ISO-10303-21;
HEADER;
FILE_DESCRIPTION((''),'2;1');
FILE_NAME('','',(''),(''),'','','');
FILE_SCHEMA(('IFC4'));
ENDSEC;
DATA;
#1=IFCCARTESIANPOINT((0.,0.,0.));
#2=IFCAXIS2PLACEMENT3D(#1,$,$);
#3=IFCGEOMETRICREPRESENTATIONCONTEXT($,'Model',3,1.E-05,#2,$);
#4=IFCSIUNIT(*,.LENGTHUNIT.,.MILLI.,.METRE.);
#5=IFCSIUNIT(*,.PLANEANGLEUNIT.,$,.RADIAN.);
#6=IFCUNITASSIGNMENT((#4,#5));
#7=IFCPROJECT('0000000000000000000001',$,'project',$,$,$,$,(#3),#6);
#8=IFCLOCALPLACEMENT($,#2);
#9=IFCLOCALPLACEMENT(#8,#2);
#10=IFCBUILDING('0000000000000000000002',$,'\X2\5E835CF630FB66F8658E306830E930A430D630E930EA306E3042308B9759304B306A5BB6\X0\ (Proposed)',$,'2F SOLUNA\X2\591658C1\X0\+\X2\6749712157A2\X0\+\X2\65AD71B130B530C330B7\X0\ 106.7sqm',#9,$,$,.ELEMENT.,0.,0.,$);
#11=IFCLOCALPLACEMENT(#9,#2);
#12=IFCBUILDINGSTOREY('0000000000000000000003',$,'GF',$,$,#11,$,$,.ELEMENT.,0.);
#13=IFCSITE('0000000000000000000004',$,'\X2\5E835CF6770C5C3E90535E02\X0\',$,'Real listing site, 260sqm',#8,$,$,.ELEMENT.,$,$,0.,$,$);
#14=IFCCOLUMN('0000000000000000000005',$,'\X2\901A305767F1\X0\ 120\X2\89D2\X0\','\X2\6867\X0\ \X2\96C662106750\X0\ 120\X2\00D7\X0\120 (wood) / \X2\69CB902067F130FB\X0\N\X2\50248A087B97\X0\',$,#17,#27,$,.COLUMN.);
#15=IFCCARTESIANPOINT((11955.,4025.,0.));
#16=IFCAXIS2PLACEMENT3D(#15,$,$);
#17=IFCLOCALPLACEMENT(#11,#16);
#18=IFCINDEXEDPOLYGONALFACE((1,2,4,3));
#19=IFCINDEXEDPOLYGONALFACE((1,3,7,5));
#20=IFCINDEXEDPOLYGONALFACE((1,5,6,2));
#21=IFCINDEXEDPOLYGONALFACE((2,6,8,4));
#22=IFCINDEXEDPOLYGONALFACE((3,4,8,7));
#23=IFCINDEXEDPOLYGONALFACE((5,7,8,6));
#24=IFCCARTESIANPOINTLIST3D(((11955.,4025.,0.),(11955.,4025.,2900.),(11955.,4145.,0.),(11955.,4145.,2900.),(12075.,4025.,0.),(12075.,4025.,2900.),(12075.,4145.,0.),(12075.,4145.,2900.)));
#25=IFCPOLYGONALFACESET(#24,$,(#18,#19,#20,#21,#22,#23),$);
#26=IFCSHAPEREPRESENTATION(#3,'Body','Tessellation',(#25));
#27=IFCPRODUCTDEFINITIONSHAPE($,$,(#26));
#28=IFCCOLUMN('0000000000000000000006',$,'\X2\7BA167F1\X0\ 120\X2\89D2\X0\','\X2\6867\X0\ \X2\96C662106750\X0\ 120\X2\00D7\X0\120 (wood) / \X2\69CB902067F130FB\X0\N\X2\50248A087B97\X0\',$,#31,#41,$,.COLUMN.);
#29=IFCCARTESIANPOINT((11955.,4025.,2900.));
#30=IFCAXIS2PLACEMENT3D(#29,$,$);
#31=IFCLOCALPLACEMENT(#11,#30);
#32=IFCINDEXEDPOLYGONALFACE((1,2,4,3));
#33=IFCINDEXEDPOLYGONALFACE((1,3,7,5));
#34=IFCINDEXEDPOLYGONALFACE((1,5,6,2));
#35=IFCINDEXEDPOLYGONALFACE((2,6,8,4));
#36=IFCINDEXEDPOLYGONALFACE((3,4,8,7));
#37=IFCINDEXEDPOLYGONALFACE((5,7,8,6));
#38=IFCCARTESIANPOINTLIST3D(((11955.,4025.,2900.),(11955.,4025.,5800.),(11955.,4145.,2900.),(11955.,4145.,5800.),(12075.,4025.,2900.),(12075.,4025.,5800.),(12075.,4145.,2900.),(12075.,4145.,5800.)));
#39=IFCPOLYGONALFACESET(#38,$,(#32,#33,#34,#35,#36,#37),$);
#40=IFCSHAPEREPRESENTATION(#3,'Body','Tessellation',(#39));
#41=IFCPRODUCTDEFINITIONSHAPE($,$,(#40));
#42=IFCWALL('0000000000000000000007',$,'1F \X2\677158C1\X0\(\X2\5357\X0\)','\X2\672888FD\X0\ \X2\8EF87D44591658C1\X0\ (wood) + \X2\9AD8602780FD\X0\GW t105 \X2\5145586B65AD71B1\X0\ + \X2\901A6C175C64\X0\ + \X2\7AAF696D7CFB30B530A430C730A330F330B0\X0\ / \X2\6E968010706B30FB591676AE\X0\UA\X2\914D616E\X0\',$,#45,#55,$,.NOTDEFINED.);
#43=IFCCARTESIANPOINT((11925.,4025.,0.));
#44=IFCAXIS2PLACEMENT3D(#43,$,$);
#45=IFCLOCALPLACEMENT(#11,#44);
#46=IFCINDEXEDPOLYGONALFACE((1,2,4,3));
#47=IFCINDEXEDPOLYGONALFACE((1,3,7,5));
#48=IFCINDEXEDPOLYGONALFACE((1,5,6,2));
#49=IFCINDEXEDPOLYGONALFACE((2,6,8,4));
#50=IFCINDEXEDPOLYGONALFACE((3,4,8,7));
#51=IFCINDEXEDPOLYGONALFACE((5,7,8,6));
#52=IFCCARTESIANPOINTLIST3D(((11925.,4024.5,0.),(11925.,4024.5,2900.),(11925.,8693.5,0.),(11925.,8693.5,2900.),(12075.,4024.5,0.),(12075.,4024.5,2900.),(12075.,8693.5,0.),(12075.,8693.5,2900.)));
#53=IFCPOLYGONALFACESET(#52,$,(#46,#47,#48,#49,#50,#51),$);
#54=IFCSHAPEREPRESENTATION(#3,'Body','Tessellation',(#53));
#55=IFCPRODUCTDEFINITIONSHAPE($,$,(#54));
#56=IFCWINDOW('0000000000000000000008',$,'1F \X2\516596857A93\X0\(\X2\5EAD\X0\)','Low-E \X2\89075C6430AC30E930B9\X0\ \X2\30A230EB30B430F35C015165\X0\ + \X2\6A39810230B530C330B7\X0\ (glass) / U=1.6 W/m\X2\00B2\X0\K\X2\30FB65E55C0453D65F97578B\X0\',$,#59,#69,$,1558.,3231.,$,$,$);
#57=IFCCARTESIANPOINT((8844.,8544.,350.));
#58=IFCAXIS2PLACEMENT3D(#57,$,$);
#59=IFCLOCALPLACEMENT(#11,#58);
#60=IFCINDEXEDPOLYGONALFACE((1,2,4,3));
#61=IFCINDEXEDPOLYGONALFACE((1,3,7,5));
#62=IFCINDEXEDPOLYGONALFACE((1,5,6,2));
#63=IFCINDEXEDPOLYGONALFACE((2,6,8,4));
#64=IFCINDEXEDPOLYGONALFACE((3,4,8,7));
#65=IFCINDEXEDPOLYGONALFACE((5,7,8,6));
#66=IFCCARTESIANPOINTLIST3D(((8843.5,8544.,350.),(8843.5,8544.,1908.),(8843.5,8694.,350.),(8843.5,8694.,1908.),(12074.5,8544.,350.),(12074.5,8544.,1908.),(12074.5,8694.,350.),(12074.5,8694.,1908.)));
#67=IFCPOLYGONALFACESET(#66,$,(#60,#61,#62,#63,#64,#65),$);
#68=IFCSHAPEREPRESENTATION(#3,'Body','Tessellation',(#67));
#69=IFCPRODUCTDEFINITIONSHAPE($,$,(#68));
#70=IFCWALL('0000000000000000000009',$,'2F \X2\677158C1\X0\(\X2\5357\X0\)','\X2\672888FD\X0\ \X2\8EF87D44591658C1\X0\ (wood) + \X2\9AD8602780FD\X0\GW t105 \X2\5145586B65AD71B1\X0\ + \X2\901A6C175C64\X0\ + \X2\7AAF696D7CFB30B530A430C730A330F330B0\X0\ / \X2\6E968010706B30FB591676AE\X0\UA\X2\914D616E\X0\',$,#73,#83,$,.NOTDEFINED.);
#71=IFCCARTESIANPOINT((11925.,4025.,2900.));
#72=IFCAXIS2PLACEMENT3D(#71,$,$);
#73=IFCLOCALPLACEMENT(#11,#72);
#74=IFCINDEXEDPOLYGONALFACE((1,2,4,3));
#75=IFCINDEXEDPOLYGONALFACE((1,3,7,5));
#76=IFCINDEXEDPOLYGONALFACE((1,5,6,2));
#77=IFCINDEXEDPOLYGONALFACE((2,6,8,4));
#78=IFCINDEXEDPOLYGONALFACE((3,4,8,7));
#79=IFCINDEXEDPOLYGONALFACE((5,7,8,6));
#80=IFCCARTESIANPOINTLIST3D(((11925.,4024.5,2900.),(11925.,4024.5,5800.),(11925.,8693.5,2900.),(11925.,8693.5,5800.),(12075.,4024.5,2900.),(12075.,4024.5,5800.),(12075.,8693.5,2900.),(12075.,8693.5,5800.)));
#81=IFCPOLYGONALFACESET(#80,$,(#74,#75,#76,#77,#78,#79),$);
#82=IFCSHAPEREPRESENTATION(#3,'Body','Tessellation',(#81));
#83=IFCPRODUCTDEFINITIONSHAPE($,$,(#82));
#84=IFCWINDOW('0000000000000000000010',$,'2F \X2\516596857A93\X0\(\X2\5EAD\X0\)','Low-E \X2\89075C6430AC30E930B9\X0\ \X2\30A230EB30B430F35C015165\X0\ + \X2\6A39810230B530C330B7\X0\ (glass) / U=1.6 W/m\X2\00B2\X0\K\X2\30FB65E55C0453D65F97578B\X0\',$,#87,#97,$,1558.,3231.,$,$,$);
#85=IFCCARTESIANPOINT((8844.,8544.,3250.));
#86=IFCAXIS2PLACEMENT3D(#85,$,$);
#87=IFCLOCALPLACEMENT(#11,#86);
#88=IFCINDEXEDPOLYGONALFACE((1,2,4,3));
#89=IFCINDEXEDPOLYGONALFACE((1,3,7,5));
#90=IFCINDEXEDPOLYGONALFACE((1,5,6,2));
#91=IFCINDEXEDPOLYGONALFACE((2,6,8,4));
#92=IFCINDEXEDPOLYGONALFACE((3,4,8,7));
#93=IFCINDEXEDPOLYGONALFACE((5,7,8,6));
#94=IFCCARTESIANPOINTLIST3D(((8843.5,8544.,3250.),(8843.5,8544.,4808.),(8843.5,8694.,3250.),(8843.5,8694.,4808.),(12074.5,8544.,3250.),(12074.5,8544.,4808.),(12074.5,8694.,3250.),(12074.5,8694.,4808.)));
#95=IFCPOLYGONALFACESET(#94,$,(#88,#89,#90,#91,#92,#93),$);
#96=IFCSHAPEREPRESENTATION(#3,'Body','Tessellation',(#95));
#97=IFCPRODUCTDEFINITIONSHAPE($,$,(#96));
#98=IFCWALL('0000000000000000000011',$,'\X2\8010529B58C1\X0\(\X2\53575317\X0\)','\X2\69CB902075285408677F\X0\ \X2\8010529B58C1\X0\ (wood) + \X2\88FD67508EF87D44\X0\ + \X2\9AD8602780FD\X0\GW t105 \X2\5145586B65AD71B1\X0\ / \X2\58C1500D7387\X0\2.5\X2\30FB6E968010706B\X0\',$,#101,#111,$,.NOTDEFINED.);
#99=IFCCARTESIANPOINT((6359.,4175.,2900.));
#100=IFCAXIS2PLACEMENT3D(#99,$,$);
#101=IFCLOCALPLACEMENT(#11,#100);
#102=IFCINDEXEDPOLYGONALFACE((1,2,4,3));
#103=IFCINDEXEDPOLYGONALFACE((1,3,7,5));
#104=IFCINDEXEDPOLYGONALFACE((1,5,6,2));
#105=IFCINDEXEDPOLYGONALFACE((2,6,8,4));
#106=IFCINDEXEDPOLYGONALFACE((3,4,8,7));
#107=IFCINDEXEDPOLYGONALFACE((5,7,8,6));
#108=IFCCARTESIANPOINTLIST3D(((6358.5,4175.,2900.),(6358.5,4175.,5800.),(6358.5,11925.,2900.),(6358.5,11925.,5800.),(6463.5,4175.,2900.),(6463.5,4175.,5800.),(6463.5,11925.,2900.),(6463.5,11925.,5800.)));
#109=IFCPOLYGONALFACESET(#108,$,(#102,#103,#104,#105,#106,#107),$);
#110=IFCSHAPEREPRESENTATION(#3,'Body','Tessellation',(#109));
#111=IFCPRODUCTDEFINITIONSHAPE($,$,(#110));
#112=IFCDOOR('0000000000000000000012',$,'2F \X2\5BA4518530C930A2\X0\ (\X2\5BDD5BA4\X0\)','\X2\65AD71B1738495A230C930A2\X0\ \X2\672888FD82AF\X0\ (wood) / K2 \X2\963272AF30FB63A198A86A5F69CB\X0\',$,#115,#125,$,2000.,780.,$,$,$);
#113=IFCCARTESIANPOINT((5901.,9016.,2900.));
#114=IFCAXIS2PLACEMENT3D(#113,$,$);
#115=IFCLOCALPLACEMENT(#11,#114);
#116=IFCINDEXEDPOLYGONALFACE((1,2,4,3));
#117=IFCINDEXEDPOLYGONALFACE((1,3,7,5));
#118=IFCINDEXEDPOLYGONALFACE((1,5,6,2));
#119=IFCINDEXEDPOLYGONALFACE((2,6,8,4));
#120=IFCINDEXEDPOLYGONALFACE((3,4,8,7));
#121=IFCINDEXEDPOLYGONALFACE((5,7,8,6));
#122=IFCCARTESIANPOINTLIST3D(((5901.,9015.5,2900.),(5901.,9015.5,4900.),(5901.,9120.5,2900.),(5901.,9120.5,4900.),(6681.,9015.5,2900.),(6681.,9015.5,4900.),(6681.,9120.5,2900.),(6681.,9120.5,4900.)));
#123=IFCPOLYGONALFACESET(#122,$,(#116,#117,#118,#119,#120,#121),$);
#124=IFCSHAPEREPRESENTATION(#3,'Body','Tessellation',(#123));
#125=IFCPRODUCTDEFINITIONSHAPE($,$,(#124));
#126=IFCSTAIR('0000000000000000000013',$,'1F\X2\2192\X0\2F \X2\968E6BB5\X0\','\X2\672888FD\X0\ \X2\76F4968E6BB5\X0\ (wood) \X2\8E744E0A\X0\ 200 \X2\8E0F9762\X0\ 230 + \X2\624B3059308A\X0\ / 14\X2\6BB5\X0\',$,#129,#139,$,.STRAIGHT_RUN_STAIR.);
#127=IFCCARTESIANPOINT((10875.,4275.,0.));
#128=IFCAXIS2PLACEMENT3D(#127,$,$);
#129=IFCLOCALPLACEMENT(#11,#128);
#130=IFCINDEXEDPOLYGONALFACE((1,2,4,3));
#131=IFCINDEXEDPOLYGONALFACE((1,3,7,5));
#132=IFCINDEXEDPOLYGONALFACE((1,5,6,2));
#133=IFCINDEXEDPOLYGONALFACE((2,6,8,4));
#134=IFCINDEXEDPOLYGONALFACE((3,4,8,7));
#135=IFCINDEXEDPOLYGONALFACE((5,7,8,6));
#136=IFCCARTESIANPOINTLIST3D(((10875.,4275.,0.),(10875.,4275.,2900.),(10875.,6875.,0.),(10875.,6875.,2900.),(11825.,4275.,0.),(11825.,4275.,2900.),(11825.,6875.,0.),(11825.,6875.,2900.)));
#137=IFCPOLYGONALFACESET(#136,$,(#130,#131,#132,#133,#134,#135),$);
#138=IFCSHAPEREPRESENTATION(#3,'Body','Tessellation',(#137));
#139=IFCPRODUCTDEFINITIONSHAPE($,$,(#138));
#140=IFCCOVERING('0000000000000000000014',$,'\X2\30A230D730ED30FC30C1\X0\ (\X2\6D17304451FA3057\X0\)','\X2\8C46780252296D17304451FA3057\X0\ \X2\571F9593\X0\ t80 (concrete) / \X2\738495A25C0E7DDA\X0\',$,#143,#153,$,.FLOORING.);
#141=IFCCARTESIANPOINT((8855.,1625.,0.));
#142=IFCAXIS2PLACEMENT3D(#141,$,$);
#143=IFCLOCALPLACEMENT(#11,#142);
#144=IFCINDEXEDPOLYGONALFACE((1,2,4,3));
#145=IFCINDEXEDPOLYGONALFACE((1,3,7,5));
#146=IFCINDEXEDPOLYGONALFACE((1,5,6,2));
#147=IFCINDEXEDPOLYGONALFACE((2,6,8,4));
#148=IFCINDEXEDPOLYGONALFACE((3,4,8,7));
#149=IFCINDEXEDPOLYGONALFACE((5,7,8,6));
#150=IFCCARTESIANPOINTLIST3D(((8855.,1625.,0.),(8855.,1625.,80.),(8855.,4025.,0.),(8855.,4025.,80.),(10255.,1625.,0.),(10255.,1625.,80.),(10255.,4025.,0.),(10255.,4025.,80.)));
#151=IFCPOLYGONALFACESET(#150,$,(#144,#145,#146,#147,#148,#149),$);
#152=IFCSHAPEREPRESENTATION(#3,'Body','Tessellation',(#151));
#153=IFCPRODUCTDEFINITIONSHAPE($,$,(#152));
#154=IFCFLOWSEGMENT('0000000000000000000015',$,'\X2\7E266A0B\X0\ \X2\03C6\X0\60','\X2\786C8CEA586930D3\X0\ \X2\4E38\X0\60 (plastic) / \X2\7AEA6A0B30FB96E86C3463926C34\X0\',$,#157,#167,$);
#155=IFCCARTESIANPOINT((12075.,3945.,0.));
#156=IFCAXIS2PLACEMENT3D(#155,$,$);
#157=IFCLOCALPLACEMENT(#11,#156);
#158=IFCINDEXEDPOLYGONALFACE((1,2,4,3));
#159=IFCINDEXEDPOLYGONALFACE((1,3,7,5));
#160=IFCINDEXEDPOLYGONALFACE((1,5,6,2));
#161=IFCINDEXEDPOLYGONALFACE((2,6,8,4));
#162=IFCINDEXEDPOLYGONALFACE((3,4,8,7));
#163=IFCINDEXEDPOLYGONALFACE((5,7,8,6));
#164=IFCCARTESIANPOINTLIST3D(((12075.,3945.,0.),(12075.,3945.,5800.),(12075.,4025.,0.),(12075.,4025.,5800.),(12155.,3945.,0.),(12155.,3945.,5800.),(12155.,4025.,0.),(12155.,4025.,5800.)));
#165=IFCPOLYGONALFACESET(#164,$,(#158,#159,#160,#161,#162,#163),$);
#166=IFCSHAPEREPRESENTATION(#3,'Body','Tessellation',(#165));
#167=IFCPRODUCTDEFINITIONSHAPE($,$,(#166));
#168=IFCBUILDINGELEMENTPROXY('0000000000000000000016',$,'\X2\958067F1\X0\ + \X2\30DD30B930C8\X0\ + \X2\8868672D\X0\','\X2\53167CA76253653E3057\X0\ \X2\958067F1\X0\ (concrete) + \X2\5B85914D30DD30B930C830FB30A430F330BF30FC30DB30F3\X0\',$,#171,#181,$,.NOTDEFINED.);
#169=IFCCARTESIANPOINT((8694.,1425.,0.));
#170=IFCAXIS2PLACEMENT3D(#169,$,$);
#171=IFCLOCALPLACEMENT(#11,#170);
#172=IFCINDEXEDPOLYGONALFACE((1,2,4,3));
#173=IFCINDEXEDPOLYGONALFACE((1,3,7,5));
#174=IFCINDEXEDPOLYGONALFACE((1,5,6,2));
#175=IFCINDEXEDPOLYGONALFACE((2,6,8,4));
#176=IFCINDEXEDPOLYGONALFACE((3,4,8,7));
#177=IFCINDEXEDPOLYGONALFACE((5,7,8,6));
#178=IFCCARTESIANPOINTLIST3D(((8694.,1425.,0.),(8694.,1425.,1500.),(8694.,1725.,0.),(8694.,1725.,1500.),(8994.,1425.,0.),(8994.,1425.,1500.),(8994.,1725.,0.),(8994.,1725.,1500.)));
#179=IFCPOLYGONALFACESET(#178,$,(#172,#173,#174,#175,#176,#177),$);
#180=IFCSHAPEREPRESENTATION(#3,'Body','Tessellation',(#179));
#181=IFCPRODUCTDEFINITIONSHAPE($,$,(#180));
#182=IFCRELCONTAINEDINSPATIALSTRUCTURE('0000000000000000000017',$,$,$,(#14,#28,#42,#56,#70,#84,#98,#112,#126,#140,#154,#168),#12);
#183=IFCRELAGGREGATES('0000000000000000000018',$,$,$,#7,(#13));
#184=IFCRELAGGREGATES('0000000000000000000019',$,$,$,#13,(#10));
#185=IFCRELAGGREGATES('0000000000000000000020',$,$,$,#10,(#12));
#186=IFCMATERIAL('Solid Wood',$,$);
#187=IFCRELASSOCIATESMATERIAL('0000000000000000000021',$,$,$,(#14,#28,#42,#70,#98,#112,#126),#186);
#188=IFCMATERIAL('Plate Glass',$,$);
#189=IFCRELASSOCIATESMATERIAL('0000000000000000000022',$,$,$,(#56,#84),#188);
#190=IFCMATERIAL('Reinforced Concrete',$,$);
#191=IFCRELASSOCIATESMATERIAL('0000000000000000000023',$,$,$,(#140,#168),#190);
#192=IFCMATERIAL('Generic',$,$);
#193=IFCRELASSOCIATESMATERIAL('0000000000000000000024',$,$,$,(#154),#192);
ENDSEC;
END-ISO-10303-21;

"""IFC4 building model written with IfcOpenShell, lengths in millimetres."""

from ifc_helpers import new_model, si_unit, frame, frame_2d, origin, place, context, project, spatial, rectangle, extrude, material, element, fill, save


model = new_model("IFC4")

# Units and contexts
model_context = context("Model", 3, precision=1e-05, world=origin())
ifc_project = project(units=[si_unit("LENGTHUNIT", "METRE", prefix="MILLI"), si_unit("PLANEANGLEUNIT", "RADIAN")], contexts=[model_context])

# Site, building, storey
site_placement = place(None, origin())
site = spatial("IfcSite", under=ifc_project, at=site_placement, Name="広島県尾道市", ObjectType="Real listing site, 260sqm", CompositionType="ELEMENT", RefElevation=0.0)
building_placement = place(site_placement, origin())
building = spatial("IfcBuilding", under=site, at=building_placement, Name="広島・書斎とライブラリのある静かな家 (Proposed)", ObjectType="2F SOLUNA外壁+杉無垢+断熱サッシ 106.7sqm", CompositionType="ELEMENT", ElevationOfRefHeight=0.0, ElevationOfTerrain=0.0)
storey_placement = place(building_placement, origin())
storey = spatial("IfcBuildingStorey", under=building, at=storey_placement, Name="GF", CompositionType="ELEMENT", Elevation=0.0)

# Columns
ifc_material_1 = material(Name="Solid Wood")
column_1_placement = place(storey_placement, frame((11955.0, 4025.0, 0.0)))
element("IfcColumn", 1, at=column_1_placement, inside=storey, material=ifc_material_1, Name="通し柱 120角", Description="桧 集成材 120×120 (wood) / 構造柱・N値計算", PredefinedType="COLUMN", context=model_context, shape_type="SweptSolid", body=[
    extrude(rectangle(XDim=120.0, YDim=120.0, at=frame_2d((60.0, 60.0))), frame((11955.0, 4025.0, 0.0)), (0.0, 0.0, 1.0), 2900.0),
])
column_2_placement = place(storey_placement, frame((11955.0, 4025.0, 2900.0)))
element("IfcColumn", 2, at=column_2_placement, inside=storey, material=ifc_material_1, Name="管柱 120角", Description="桧 集成材 120×120 (wood) / 構造柱・N値計算", PredefinedType="COLUMN", context=model_context, shape_type="SweptSolid", body=[
    extrude(rectangle(XDim=120.0, YDim=120.0, at=frame_2d((60.0, 60.0))), frame((11955.0, 4025.0, 2900.0)), (0.0, 0.0, 1.0), 2900.0),
])

# Wall, opening, window
wall_1_placement = place(storey_placement, frame((11925.0, 4025.0, 0.0)))
wall_1 = element("IfcWall", 3, at=wall_1_placement, inside=storey, material=ifc_material_1, Name="1F 東壁(南)", Description="木製 軸組外壁 (wood) + 高性能GW t105 充填断熱 + 通気層 + 窯業系サイディング / 準耐火・外皮UA配慮", PredefinedType="NOTDEFINED", context=model_context, shape_type="SweptSolid", body=[
    extrude(rectangle(XDim=150.0, YDim=4669.0, at=frame_2d((75.0, 2334.0))), frame((11925.0, 4025.0, 0.0)), (0.0, 0.0, 1.0), 2900.0),
])
opening_1_placement = place(storey_placement, frame((8844.0, 8544.0, 350.0)))
opening_1 = element("IfcOpeningElement", 4, at=opening_1_placement, cuts=wall_1, PredefinedType="NOTDEFINED", context=model_context, shape_type="SweptSolid", body=[
    extrude(rectangle(XDim=3231.0, YDim=150.0, at=frame_2d((1615.0, 75.0))), frame((8844.0, 8544.0, 350.0)), (0.0, 0.0, 1.0), 1558.0),
])
ifc_material_2 = material(Name="Plate Glass")
window_1_placement = place(storey_placement, frame((8844.0, 8544.0, 350.0)))
window_1 = element("IfcWindow", 5, at=window_1_placement, inside=storey, material=ifc_material_2, Name="1F 入隅窓(庭)", Description="Low-E 複層ガラス アルゴン封入 + 樹脂サッシ (glass) / U=1.6 W/m²K・日射取得型", OverallHeight=1558.0, OverallWidth=3231.0, context=model_context, shape_type="SweptSolid", body=[
    extrude(rectangle(XDim=3231.0, YDim=150.0, at=frame_2d((1615.0, 75.0))), frame((8844.0, 8544.0, 350.0)), (0.0, 0.0, 1.0), 1558.0),
])
fill(opening_1, window_1)

# Wall, opening, window
wall_2_placement = place(storey_placement, frame((11925.0, 4025.0, 2900.0)))
wall_2 = element("IfcWall", 6, at=wall_2_placement, inside=storey, material=ifc_material_1, Name="2F 東壁(南)", Description="木製 軸組外壁 (wood) + 高性能GW t105 充填断熱 + 通気層 + 窯業系サイディング / 準耐火・外皮UA配慮", PredefinedType="NOTDEFINED", context=model_context, shape_type="SweptSolid", body=[
    extrude(rectangle(XDim=150.0, YDim=4669.0, at=frame_2d((75.0, 2334.0))), frame((11925.0, 4025.0, 2900.0)), (0.0, 0.0, 1.0), 2900.0),
])
opening_2_placement = place(storey_placement, frame((8844.0, 8544.0, 3250.0)))
opening_2 = element("IfcOpeningElement", 7, at=opening_2_placement, cuts=wall_2, PredefinedType="NOTDEFINED", context=model_context, shape_type="SweptSolid", body=[
    extrude(rectangle(XDim=3231.0, YDim=150.0, at=frame_2d((1615.0, 75.0))), frame((8844.0, 8544.0, 3250.0)), (0.0, 0.0, 1.0), 1558.0),
])
window_2_placement = place(storey_placement, frame((8844.0, 8544.0, 3250.0)))
window_2 = element("IfcWindow", 8, at=window_2_placement, inside=storey, material=ifc_material_2, Name="2F 入隅窓(庭)", Description="Low-E 複層ガラス アルゴン封入 + 樹脂サッシ (glass) / U=1.6 W/m²K・日射取得型", OverallHeight=1558.0, OverallWidth=3231.0, context=model_context, shape_type="SweptSolid", body=[
    extrude(rectangle(XDim=3231.0, YDim=150.0, at=frame_2d((1615.0, 75.0))), frame((8844.0, 8544.0, 3250.0)), (0.0, 0.0, 1.0), 1558.0),
])
fill(opening_2, window_2)

# Wall, opening, door
wall_3_placement = place(storey_placement, frame((6359.0, 4175.0, 2900.0)))
wall_3 = element("IfcWall", 9, at=wall_3_placement, inside=storey, material=ifc_material_1, Name="耐力壁(南北)", Description="構造用合板 耐力壁 (wood) + 製材軸組 + 高性能GW t105 充填断熱 / 壁倍率2.5・準耐火", PredefinedType="NOTDEFINED", context=model_context, shape_type="SweptSolid", body=[
    extrude(rectangle(XDim=105.0, YDim=7750.0, at=frame_2d((52.0, 3875.0))), frame((6359.0, 4175.0, 2900.0)), (0.0, 0.0, 1.0), 2900.0),
])
opening_3_placement = place(storey_placement, frame((5901.0, 9016.0, 2900.0)))
opening_3 = element("IfcOpeningElement", 10, at=opening_3_placement, cuts=wall_3, PredefinedType="NOTDEFINED", context=model_context, shape_type="SweptSolid", body=[
    extrude(rectangle(XDim=780.0, YDim=105.0, at=frame_2d((390.0, 52.0))), frame((5901.0, 9016.0, 2900.0)), (0.0, 0.0, 1.0), 2000.0),
])
door_1_placement = place(storey_placement, frame((5901.0, 9016.0, 2900.0)))
door_1 = element("IfcDoor", 11, at=door_1_placement, inside=storey, material=ifc_material_1, Name="2F 室内ドア (寝室)", Description="断熱玄関ドア 木製芯 (wood) / K2 防犯・採風機構", OverallHeight=2000.0, OverallWidth=780.0, context=model_context, shape_type="SweptSolid", body=[
    extrude(rectangle(XDim=780.0, YDim=105.0, at=frame_2d((390.0, 52.0))), frame((5901.0, 9016.0, 2900.0)), (0.0, 0.0, 1.0), 2000.0),
])
fill(opening_3, door_1)

# Stair
stair_placement = place(storey_placement, frame((10875.0, 4275.0, 0.0)))
element("IfcStair", 12, at=stair_placement, inside=storey, material=ifc_material_1, Name="1F→2F 階段", Description="木製 直階段 (wood) 蹴上 200 踏面 230 + 手すり / 14段", PredefinedType="STRAIGHT_RUN_STAIR", context=model_context, shape_type="SweptSolid", body=[
    extrude(rectangle(XDim=950.0, YDim=2600.0, at=frame_2d((475.0, 1300.0))), frame((10875.0, 4275.0, 0.0)), (0.0, 0.0, 1.0), 2900.0),
])

# Covering
ifc_material_3 = material(Name="Reinforced Concrete")
covering_placement = place(storey_placement, frame((8855.0, 1625.0, 0.0)))
element("IfcCovering", 13, at=covering_placement, inside=storey, material=ifc_material_3, Name="アプローチ (洗い出し)", Description="豆砂利洗い出し 土間 t80 (concrete) / 玄関導線", PredefinedType="FLOORING", context=model_context, shape_type="SweptSolid", body=[
    extrude(rectangle(XDim=1400.0, YDim=2400.0, at=frame_2d((700.0, 1200.0))), frame((8855.0, 1625.0, 0.0)), (0.0, 0.0, 1.0), 80.0),
])

# Flow segment
ifc_material_4 = material(Name="Generic")
flow_segment_placement = place(storey_placement, frame((12075.0, 3945.0, 0.0)))
element("IfcFlowSegment", 14, at=flow_segment_placement, inside=storey, material=ifc_material_4, Name="縦樋 φ60", Description="硬質塩ビ 丸60 (plastic) / 竪樋・雨水排水", context=model_context, shape_type="SweptSolid", body=[
    extrude(rectangle(XDim=80.0, YDim=80.0, at=frame_2d((40.0, 40.0))), frame((12075.0, 3945.0, 0.0)), (0.0, 0.0, 1.0), 5800.0),
])

# Building element proxy
proxy_placement = place(storey_placement, frame((8694.0, 1425.0, 0.0)))
element("IfcBuildingElementProxy", 15, at=proxy_placement, inside=storey, material=ifc_material_3, Name="門柱 + ポスト + 表札", Description="化粧打放し 門柱 (concrete) + 宅配ポスト・インターホン", PredefinedType="NOTDEFINED", context=model_context, shape_type="SweptSolid", body=[
    extrude(rectangle(XDim=300.0, YDim=300.0, at=frame_2d((150.0, 150.0))), frame((8694.0, 1425.0, 0.0)), (0.0, 0.0, 1.0), 1500.0),
])

save(model, "model.ifc")
